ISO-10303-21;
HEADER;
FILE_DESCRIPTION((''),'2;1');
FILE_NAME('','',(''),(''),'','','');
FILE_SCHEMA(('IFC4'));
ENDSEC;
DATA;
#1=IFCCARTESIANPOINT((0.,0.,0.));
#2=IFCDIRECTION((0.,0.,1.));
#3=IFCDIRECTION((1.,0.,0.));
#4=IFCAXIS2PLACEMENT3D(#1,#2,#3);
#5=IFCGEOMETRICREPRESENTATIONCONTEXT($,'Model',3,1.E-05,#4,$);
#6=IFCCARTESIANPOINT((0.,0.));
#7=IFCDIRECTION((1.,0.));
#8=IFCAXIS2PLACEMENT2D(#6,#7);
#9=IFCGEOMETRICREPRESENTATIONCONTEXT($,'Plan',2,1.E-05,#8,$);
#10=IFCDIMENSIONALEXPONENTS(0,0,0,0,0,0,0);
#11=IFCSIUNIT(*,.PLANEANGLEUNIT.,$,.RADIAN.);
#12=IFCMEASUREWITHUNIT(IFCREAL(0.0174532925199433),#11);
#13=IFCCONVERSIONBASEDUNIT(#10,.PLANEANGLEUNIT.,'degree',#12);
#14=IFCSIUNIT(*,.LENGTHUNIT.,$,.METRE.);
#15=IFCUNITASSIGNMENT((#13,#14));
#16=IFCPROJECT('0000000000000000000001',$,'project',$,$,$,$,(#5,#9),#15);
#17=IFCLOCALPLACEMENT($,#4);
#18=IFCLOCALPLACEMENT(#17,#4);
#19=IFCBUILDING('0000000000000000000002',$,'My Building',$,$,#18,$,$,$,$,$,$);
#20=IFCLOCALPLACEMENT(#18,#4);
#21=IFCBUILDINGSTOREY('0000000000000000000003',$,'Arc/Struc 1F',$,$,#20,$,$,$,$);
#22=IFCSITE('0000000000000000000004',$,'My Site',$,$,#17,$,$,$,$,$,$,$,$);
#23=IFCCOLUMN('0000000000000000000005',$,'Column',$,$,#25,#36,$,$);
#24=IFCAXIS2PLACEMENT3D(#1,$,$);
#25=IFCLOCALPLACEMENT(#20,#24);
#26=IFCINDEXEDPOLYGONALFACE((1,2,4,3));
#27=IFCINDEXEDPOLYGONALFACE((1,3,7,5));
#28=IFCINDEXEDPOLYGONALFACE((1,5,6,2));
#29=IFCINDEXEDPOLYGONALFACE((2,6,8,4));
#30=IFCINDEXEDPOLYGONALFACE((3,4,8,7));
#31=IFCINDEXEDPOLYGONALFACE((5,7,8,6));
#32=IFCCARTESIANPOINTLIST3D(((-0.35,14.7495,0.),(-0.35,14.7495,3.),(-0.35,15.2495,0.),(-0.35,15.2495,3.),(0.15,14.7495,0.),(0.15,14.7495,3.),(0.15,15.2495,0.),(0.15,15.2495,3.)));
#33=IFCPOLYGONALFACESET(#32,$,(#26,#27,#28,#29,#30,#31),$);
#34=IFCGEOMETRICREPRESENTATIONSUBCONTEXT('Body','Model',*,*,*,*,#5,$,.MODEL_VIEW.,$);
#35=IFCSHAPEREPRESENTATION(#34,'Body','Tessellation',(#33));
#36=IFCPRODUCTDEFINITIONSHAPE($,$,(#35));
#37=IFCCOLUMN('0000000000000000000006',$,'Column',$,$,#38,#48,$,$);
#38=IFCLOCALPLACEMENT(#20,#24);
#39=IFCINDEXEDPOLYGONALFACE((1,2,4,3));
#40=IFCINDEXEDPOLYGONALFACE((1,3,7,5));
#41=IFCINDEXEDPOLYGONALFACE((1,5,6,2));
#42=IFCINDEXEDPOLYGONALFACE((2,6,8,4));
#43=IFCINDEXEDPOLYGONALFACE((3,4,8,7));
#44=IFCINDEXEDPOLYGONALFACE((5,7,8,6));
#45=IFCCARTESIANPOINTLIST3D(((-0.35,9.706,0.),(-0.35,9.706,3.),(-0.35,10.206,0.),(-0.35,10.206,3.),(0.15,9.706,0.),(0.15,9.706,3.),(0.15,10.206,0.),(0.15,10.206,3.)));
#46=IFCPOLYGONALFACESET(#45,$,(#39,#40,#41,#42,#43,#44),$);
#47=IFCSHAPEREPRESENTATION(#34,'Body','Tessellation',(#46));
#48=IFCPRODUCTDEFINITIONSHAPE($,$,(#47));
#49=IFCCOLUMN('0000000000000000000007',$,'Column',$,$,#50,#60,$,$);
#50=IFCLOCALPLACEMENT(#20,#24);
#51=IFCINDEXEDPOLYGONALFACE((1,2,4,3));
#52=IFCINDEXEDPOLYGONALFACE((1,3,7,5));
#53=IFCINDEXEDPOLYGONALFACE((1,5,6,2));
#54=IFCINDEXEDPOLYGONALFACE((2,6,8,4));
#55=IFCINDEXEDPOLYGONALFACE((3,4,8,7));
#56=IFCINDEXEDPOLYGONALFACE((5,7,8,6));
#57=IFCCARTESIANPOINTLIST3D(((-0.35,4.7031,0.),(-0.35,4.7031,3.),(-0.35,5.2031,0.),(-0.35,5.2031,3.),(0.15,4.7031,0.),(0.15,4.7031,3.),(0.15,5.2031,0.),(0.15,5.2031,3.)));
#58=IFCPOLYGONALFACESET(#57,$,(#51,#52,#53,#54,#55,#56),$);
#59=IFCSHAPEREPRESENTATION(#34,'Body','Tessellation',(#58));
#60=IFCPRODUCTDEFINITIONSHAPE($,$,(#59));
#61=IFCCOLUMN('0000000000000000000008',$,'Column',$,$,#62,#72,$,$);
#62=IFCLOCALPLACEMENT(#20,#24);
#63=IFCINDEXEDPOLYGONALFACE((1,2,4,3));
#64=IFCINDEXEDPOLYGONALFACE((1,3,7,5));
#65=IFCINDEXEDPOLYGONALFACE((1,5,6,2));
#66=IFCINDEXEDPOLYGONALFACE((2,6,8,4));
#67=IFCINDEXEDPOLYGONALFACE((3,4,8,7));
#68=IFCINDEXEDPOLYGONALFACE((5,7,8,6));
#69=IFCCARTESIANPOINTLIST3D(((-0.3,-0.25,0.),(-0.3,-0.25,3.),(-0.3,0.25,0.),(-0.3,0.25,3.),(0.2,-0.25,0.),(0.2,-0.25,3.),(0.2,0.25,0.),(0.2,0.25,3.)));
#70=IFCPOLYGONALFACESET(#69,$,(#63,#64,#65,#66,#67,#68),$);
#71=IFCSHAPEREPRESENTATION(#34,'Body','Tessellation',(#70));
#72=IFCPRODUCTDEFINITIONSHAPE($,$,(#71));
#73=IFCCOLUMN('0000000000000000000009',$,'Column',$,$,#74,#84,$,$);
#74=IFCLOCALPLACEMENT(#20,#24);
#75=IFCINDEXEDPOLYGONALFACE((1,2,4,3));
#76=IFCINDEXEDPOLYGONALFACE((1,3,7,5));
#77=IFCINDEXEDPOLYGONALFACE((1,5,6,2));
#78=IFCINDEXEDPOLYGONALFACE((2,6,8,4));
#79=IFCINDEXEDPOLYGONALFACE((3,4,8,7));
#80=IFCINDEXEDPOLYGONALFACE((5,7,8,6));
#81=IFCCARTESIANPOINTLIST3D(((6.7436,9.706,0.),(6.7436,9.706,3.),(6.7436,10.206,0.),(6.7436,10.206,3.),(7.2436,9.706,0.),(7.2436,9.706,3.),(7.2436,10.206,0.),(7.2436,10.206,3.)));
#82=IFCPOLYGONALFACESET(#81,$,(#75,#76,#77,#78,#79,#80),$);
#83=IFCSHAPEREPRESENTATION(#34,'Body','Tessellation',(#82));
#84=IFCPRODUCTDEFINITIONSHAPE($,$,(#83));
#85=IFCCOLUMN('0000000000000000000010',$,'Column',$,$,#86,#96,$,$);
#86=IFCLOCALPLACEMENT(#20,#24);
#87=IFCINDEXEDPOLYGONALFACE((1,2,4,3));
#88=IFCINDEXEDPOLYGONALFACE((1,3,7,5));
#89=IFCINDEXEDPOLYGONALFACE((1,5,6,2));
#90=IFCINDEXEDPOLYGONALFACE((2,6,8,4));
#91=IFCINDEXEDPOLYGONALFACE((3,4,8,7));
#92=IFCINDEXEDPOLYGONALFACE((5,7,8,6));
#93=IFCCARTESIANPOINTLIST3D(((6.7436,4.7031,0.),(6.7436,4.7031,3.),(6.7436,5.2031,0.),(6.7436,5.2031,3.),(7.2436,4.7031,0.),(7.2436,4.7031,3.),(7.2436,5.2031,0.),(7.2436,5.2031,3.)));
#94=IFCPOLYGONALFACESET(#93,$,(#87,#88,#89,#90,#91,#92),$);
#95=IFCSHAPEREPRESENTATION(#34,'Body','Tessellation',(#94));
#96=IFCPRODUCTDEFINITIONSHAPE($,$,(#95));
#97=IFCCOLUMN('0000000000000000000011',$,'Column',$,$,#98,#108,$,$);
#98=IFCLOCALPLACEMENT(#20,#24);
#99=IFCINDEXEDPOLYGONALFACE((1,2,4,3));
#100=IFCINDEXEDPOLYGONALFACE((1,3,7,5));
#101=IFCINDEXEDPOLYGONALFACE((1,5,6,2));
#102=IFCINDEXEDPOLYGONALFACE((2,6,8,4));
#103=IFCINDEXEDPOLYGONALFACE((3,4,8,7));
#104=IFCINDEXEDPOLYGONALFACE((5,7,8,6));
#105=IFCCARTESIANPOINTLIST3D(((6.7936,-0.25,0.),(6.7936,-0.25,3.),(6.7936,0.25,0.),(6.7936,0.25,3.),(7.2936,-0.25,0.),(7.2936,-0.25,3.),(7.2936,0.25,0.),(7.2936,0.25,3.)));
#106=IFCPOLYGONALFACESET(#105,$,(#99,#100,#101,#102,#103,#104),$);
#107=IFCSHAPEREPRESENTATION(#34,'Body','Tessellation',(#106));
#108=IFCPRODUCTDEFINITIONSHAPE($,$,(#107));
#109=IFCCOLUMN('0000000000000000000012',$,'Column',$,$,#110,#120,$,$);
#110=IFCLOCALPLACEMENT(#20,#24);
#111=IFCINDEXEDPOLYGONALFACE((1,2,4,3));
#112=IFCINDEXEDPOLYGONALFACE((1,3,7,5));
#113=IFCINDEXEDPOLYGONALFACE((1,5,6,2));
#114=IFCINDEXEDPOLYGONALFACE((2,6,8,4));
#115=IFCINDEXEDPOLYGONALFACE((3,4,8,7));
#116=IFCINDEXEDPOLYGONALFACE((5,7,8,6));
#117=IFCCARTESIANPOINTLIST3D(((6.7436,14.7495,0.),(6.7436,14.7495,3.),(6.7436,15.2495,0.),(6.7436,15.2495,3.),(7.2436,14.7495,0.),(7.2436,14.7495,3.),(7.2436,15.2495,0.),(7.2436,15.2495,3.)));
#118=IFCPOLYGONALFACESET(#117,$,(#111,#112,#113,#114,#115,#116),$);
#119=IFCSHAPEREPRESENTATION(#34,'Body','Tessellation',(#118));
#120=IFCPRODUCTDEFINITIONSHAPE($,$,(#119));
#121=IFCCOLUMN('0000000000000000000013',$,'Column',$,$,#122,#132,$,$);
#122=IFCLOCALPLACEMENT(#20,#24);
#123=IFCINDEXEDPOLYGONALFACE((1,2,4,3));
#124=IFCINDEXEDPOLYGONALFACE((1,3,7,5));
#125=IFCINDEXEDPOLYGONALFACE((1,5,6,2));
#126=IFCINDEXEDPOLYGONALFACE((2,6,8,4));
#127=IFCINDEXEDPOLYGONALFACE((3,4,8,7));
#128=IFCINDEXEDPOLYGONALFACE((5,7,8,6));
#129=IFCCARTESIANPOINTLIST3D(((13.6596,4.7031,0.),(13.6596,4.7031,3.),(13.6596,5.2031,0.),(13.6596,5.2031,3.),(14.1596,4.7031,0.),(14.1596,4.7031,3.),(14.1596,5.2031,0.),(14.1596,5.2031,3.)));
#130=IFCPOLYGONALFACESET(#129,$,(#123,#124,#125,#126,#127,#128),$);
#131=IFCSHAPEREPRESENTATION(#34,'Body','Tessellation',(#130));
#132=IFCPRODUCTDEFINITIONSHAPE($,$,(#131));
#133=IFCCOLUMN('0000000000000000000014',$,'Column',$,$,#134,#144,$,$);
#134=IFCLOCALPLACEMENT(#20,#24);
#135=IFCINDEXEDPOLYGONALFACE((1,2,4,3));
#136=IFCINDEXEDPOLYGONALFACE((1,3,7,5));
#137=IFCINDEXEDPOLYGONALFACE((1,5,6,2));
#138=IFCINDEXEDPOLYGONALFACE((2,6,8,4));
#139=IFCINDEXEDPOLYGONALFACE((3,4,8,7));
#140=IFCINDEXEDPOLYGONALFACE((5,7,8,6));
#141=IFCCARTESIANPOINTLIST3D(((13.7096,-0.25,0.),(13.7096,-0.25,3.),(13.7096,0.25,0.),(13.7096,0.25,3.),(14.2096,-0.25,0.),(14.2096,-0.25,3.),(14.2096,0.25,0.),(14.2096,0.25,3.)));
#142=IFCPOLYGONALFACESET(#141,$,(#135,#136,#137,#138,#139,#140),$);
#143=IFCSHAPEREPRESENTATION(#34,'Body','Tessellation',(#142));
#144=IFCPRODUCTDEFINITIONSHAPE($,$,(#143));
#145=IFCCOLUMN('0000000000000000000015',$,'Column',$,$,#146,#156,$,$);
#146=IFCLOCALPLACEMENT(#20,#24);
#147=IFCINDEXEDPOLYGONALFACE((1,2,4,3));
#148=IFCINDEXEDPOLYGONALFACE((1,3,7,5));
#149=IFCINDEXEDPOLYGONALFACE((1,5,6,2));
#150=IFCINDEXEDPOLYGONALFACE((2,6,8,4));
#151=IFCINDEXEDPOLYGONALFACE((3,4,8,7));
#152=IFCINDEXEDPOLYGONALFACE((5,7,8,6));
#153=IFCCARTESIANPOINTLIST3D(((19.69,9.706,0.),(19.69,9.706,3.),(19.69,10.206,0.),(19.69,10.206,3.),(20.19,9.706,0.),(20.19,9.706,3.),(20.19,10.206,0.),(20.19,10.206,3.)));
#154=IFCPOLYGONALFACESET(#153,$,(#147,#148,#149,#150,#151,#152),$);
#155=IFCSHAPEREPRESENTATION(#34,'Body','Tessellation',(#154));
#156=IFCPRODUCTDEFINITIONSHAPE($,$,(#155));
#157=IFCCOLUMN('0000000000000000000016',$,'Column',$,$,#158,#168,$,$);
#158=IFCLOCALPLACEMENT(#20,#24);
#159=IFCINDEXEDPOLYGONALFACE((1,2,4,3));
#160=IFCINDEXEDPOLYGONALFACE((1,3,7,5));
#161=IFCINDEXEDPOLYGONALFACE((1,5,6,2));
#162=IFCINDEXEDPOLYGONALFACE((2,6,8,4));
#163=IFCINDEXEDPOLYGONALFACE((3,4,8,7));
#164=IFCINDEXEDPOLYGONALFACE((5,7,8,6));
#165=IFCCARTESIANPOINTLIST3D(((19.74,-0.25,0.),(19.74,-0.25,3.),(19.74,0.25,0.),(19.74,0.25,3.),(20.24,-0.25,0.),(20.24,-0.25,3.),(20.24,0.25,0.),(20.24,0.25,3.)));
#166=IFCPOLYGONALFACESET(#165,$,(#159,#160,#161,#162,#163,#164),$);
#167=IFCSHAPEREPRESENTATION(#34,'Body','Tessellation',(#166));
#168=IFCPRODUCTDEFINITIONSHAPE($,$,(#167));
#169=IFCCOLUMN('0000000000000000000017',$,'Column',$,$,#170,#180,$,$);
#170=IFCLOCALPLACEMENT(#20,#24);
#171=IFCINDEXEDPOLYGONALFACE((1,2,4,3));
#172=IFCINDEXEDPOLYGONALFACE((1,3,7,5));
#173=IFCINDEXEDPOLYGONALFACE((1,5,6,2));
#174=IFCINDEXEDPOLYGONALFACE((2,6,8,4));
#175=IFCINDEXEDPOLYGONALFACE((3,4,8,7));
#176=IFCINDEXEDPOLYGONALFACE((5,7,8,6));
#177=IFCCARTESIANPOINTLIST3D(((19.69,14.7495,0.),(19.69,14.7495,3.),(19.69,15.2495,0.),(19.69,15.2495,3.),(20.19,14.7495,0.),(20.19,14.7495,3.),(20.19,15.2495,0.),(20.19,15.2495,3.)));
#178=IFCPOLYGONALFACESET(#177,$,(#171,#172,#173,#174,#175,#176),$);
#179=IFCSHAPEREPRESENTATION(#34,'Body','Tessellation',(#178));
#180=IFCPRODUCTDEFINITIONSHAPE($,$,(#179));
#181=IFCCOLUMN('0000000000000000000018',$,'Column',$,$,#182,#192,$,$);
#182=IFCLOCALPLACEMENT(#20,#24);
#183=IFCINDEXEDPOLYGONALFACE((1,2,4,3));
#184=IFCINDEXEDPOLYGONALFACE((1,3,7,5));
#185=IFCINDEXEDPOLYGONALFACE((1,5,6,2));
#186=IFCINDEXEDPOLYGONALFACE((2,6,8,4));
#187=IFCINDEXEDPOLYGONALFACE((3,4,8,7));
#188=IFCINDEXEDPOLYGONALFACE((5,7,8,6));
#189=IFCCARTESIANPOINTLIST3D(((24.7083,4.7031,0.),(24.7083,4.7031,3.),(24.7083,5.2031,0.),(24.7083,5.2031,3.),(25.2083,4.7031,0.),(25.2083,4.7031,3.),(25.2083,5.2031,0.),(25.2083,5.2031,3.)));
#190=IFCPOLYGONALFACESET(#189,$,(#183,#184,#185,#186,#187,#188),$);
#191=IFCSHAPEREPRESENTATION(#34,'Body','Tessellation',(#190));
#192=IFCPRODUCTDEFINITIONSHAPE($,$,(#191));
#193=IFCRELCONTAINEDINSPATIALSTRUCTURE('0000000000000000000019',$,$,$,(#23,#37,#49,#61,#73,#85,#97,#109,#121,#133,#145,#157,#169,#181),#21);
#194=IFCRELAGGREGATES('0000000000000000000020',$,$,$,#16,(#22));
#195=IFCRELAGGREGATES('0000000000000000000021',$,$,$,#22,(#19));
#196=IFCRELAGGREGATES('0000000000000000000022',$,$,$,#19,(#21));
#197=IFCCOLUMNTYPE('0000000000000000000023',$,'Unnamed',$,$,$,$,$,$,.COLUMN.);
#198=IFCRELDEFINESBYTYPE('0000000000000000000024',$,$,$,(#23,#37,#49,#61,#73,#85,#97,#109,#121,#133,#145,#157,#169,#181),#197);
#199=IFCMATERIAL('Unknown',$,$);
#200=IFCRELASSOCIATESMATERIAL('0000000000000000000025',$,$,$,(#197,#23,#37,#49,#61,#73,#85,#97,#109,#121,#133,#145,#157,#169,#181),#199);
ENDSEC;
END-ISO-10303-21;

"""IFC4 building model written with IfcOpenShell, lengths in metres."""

from ifc_helpers import new_model, entity, si_unit, converted_unit, frame, origin_with_axes, origin_2d_with_axis, place, context, subcontext, project, spatial, rectangle, extrude, material, material_profile, profile_set, profile_usage, type_object, element, save


model = new_model("IFC4")

# Units and contexts
model_context = context("Model", 3, precision=1e-05, world=origin_with_axes())
plan_context = context("Plan", 2, precision=1e-05, world=origin_2d_with_axis())
body_context_1 = subcontext(model_context, "Body", "Model", "MODEL_VIEW")
ifc_project = project(units=[converted_unit("PLANEANGLEUNIT", "degree", entity("IfcReal", 0.0174532925199433), si_unit("PLANEANGLEUNIT", "RADIAN"), dimensions=[0, 0, 0, 0, 0, 0, 0]), si_unit("LENGTHUNIT", "METRE")], contexts=[model_context, plan_context])

# Site, building, storey
site_placement = place(None, origin_with_axes())
site = spatial("IfcSite", under=ifc_project, at=site_placement, Name="My Site")
building_placement = place(site_placement, origin_with_axes())
building = spatial("IfcBuilding", under=site, at=building_placement, Name="My Building")
storey_placement = place(building_placement, origin_with_axes())
storey = spatial("IfcBuildingStorey", under=building, at=storey_placement, Name="Arc/Struc 1F")

# Columns
ifc_material = material(Name="Unknown")
ifc_material_profile = material_profile(ifc_material, rectangle(XDim=0.5, YDim=0.5))
ifc_profile_set = profile_set([ifc_material_profile])
ifc_profile_usage_1 = profile_usage(ifc_profile_set, cardinal=5)
column_type = type_object("IfcColumnType", Name="Unnamed", PredefinedType="COLUMN", material=ifc_profile_set)
column_1_placement = place(storey_placement, frame((-0.1, 14.9995, 0.0), z_axis=(0.0, 0.0, 1.0), x_axis=(1.0, 0.0, 0.0)))
element("IfcColumn", 1, at=column_1_placement, inside=storey, type_object=column_type, material=ifc_profile_usage_1, Name="Column", context=body_context_1, shape_type="SweptSolid", body=[
    extrude(rectangle(XDim=0.5, YDim=0.5), origin_with_axes(), (0.0, 0.0, 1.0), 3.0),
])
ifc_profile_usage_2 = profile_usage(ifc_profile_set, cardinal=5)
column_2_placement = place(storey_placement, frame((-0.1, 9.956, 0.0), z_axis=(0.0, 0.0, 1.0), x_axis=(1.0, 0.0, 0.0)))
element("IfcColumn", 2, at=column_2_placement, inside=storey, type_object=column_type, material=ifc_profile_usage_2, Name="Column", context=body_context_1, shape_type="SweptSolid", body=[
    extrude(rectangle(XDim=0.5, YDim=0.5), origin_with_axes(), (0.0, 0.0, 1.0), 3.0),
])
ifc_profile_usage_3 = profile_usage(ifc_profile_set, cardinal=5)
column_3_placement = place(storey_placement, frame((-0.1, 4.9531, 0.0), z_axis=(0.0, 0.0, 1.0), x_axis=(1.0, 0.0, 0.0)))
element("IfcColumn", 3, at=column_3_placement, inside=storey, type_object=column_type, material=ifc_profile_usage_3, Name="Column", context=body_context_1, shape_type="SweptSolid", body=[
    extrude(rectangle(XDim=0.5, YDim=0.5), origin_with_axes(), (0.0, 0.0, 1.0), 3.0),
])
ifc_profile_usage_4 = profile_usage(ifc_profile_set, cardinal=5)
column_4_placement = place(storey_placement, frame((-0.05, 0.0, 0.0), z_axis=(0.0, 0.0, 1.0), x_axis=(1.0, 0.0, 0.0)))
element("IfcColumn", 4, at=column_4_placement, inside=storey, type_object=column_type, material=ifc_profile_usage_4, Name="Column", context=body_context_1, shape_type="SweptSolid", body=[
    extrude(rectangle(XDim=0.5, YDim=0.5), origin_with_axes(), (0.0, 0.0, 1.0), 3.0),
])
ifc_profile_usage_5 = profile_usage(ifc_profile_set, cardinal=5)
column_5_placement = place(storey_placement, frame((6.9936, 9.956, 0.0), z_axis=(0.0, 0.0, 1.0), x_axis=(1.0, 0.0, 0.0)))
element("IfcColumn", 5, at=column_5_placement, inside=storey, type_object=column_type, material=ifc_profile_usage_5, Name="Column", context=body_context_1, shape_type="SweptSolid", body=[
    extrude(rectangle(XDim=0.5, YDim=0.5), origin_with_axes(), (0.0, 0.0, 1.0), 3.0),
])
ifc_profile_usage_6 = profile_usage(ifc_profile_set, cardinal=5)
column_6_placement = place(storey_placement, frame((6.9936, 4.9531, 0.0), z_axis=(0.0, 0.0, 1.0), x_axis=(1.0, 0.0, 0.0)))
element("IfcColumn", 6, at=column_6_placement, inside=storey, type_object=column_type, material=ifc_profile_usage_6, Name="Column", context=body_context_1, shape_type="SweptSolid", body=[
    extrude(rectangle(XDim=0.5, YDim=0.5), origin_with_axes(), (0.0, 0.0, 1.0), 3.0),
])
ifc_profile_usage_7 = profile_usage(ifc_profile_set, cardinal=5)
column_7_placement = place(storey_placement, frame((7.0436, 0.0, 0.0), z_axis=(0.0, 0.0, 1.0), x_axis=(1.0, 0.0, 0.0)))
element("IfcColumn", 7, at=column_7_placement, inside=storey, type_object=column_type, material=ifc_profile_usage_7, Name="Column", context=body_context_1, shape_type="SweptSolid", body=[
    extrude(rectangle(XDim=0.5, YDim=0.5), origin_with_axes(), (0.0, 0.0, 1.0), 3.0),
])
ifc_profile_usage_8 = profile_usage(ifc_profile_set, cardinal=5)
column_8_placement = place(storey_placement, frame((6.9936, 14.9995, 0.0), z_axis=(0.0, 0.0, 1.0), x_axis=(1.0, 0.0, 0.0)))
element("IfcColumn", 8, at=column_8_placement, inside=storey, type_object=column_type, material=ifc_profile_usage_8, Name="Column", context=body_context_1, shape_type="SweptSolid", body=[
    extrude(rectangle(XDim=0.5, YDim=0.5), origin_with_axes(), (0.0, 0.0, 1.0), 3.0),
])
ifc_profile_usage_9 = profile_usage(ifc_profile_set, cardinal=5)
column_9_placement = place(storey_placement, frame((13.9096, 4.9531, 0.0), z_axis=(0.0, 0.0, 1.0), x_axis=(1.0, 0.0, 0.0)))
element("IfcColumn", 9, at=column_9_placement, inside=storey, type_object=column_type, material=ifc_profile_usage_9, Name="Column", context=body_context_1, shape_type="SweptSolid", body=[
    extrude(rectangle(XDim=0.5, YDim=0.5), origin_with_axes(), (0.0, 0.0, 1.0), 3.0),
])
ifc_profile_usage_10 = profile_usage(ifc_profile_set, cardinal=5)
column_10_placement = place(storey_placement, frame((13.9596, 0.0, 0.0), z_axis=(0.0, 0.0, 1.0), x_axis=(1.0, 0.0, 0.0)))
element("IfcColumn", 10, at=column_10_placement, inside=storey, type_object=column_type, material=ifc_profile_usage_10, Name="Column", context=body_context_1, shape_type="SweptSolid", body=[
    extrude(rectangle(XDim=0.5, YDim=0.5), origin_with_axes(), (0.0, 0.0, 1.0), 3.0),
])
ifc_profile_usage_11 = profile_usage(ifc_profile_set, cardinal=5)
column_11_placement = place(storey_placement, frame((19.94, 9.956, 0.0), z_axis=(0.0, 0.0, 1.0), x_axis=(1.0, 0.0, 0.0)))
element("IfcColumn", 11, at=column_11_placement, inside=storey, type_object=column_type, material=ifc_profile_usage_11, Name="Column", context=body_context_1, shape_type="SweptSolid", body=[
    extrude(rectangle(XDim=0.5, YDim=0.5), origin_with_axes(), (0.0, 0.0, 1.0), 3.0),
])
ifc_profile_usage_12 = profile_usage(ifc_profile_set, cardinal=5)
column_12_placement = place(storey_placement, frame((19.99, 0.0, 0.0), z_axis=(0.0, 0.0, 1.0), x_axis=(1.0, 0.0, 0.0)))
element("IfcColumn", 12, at=column_12_placement, inside=storey, type_object=column_type, material=ifc_profile_usage_12, Name="Column", context=body_context_1, shape_type="SweptSolid", body=[
    extrude(rectangle(XDim=0.5, YDim=0.5), origin_with_axes(), (0.0, 0.0, 1.0), 3.0),
])
ifc_profile_usage_13 = profile_usage(ifc_profile_set, cardinal=5)
column_13_placement = place(storey_placement, frame((19.94, 14.9995, 0.0), z_axis=(0.0, 0.0, 1.0), x_axis=(1.0, 0.0, 0.0)))
element("IfcColumn", 13, at=column_13_placement, inside=storey, type_object=column_type, material=ifc_profile_usage_13, Name="Column", context=body_context_1, shape_type="SweptSolid", body=[
    extrude(rectangle(XDim=0.5, YDim=0.5), origin_with_axes(), (0.0, 0.0, 1.0), 3.0),
])
ifc_profile_usage_14 = profile_usage(ifc_profile_set, cardinal=5)
column_14_placement = place(storey_placement, frame((24.9583, 4.9531, 0.0), z_axis=(0.0, 0.0, 1.0), x_axis=(1.0, 0.0, 0.0)))
element("IfcColumn", 14, at=column_14_placement, inside=storey, type_object=column_type, material=ifc_profile_usage_14, Name="Column", context=body_context_1, shape_type="SweptSolid", body=[
    extrude(rectangle(XDim=0.5, YDim=0.5), origin_with_axes(), (0.0, 0.0, 1.0), 3.0),
])

save(model, "model.ifc")
